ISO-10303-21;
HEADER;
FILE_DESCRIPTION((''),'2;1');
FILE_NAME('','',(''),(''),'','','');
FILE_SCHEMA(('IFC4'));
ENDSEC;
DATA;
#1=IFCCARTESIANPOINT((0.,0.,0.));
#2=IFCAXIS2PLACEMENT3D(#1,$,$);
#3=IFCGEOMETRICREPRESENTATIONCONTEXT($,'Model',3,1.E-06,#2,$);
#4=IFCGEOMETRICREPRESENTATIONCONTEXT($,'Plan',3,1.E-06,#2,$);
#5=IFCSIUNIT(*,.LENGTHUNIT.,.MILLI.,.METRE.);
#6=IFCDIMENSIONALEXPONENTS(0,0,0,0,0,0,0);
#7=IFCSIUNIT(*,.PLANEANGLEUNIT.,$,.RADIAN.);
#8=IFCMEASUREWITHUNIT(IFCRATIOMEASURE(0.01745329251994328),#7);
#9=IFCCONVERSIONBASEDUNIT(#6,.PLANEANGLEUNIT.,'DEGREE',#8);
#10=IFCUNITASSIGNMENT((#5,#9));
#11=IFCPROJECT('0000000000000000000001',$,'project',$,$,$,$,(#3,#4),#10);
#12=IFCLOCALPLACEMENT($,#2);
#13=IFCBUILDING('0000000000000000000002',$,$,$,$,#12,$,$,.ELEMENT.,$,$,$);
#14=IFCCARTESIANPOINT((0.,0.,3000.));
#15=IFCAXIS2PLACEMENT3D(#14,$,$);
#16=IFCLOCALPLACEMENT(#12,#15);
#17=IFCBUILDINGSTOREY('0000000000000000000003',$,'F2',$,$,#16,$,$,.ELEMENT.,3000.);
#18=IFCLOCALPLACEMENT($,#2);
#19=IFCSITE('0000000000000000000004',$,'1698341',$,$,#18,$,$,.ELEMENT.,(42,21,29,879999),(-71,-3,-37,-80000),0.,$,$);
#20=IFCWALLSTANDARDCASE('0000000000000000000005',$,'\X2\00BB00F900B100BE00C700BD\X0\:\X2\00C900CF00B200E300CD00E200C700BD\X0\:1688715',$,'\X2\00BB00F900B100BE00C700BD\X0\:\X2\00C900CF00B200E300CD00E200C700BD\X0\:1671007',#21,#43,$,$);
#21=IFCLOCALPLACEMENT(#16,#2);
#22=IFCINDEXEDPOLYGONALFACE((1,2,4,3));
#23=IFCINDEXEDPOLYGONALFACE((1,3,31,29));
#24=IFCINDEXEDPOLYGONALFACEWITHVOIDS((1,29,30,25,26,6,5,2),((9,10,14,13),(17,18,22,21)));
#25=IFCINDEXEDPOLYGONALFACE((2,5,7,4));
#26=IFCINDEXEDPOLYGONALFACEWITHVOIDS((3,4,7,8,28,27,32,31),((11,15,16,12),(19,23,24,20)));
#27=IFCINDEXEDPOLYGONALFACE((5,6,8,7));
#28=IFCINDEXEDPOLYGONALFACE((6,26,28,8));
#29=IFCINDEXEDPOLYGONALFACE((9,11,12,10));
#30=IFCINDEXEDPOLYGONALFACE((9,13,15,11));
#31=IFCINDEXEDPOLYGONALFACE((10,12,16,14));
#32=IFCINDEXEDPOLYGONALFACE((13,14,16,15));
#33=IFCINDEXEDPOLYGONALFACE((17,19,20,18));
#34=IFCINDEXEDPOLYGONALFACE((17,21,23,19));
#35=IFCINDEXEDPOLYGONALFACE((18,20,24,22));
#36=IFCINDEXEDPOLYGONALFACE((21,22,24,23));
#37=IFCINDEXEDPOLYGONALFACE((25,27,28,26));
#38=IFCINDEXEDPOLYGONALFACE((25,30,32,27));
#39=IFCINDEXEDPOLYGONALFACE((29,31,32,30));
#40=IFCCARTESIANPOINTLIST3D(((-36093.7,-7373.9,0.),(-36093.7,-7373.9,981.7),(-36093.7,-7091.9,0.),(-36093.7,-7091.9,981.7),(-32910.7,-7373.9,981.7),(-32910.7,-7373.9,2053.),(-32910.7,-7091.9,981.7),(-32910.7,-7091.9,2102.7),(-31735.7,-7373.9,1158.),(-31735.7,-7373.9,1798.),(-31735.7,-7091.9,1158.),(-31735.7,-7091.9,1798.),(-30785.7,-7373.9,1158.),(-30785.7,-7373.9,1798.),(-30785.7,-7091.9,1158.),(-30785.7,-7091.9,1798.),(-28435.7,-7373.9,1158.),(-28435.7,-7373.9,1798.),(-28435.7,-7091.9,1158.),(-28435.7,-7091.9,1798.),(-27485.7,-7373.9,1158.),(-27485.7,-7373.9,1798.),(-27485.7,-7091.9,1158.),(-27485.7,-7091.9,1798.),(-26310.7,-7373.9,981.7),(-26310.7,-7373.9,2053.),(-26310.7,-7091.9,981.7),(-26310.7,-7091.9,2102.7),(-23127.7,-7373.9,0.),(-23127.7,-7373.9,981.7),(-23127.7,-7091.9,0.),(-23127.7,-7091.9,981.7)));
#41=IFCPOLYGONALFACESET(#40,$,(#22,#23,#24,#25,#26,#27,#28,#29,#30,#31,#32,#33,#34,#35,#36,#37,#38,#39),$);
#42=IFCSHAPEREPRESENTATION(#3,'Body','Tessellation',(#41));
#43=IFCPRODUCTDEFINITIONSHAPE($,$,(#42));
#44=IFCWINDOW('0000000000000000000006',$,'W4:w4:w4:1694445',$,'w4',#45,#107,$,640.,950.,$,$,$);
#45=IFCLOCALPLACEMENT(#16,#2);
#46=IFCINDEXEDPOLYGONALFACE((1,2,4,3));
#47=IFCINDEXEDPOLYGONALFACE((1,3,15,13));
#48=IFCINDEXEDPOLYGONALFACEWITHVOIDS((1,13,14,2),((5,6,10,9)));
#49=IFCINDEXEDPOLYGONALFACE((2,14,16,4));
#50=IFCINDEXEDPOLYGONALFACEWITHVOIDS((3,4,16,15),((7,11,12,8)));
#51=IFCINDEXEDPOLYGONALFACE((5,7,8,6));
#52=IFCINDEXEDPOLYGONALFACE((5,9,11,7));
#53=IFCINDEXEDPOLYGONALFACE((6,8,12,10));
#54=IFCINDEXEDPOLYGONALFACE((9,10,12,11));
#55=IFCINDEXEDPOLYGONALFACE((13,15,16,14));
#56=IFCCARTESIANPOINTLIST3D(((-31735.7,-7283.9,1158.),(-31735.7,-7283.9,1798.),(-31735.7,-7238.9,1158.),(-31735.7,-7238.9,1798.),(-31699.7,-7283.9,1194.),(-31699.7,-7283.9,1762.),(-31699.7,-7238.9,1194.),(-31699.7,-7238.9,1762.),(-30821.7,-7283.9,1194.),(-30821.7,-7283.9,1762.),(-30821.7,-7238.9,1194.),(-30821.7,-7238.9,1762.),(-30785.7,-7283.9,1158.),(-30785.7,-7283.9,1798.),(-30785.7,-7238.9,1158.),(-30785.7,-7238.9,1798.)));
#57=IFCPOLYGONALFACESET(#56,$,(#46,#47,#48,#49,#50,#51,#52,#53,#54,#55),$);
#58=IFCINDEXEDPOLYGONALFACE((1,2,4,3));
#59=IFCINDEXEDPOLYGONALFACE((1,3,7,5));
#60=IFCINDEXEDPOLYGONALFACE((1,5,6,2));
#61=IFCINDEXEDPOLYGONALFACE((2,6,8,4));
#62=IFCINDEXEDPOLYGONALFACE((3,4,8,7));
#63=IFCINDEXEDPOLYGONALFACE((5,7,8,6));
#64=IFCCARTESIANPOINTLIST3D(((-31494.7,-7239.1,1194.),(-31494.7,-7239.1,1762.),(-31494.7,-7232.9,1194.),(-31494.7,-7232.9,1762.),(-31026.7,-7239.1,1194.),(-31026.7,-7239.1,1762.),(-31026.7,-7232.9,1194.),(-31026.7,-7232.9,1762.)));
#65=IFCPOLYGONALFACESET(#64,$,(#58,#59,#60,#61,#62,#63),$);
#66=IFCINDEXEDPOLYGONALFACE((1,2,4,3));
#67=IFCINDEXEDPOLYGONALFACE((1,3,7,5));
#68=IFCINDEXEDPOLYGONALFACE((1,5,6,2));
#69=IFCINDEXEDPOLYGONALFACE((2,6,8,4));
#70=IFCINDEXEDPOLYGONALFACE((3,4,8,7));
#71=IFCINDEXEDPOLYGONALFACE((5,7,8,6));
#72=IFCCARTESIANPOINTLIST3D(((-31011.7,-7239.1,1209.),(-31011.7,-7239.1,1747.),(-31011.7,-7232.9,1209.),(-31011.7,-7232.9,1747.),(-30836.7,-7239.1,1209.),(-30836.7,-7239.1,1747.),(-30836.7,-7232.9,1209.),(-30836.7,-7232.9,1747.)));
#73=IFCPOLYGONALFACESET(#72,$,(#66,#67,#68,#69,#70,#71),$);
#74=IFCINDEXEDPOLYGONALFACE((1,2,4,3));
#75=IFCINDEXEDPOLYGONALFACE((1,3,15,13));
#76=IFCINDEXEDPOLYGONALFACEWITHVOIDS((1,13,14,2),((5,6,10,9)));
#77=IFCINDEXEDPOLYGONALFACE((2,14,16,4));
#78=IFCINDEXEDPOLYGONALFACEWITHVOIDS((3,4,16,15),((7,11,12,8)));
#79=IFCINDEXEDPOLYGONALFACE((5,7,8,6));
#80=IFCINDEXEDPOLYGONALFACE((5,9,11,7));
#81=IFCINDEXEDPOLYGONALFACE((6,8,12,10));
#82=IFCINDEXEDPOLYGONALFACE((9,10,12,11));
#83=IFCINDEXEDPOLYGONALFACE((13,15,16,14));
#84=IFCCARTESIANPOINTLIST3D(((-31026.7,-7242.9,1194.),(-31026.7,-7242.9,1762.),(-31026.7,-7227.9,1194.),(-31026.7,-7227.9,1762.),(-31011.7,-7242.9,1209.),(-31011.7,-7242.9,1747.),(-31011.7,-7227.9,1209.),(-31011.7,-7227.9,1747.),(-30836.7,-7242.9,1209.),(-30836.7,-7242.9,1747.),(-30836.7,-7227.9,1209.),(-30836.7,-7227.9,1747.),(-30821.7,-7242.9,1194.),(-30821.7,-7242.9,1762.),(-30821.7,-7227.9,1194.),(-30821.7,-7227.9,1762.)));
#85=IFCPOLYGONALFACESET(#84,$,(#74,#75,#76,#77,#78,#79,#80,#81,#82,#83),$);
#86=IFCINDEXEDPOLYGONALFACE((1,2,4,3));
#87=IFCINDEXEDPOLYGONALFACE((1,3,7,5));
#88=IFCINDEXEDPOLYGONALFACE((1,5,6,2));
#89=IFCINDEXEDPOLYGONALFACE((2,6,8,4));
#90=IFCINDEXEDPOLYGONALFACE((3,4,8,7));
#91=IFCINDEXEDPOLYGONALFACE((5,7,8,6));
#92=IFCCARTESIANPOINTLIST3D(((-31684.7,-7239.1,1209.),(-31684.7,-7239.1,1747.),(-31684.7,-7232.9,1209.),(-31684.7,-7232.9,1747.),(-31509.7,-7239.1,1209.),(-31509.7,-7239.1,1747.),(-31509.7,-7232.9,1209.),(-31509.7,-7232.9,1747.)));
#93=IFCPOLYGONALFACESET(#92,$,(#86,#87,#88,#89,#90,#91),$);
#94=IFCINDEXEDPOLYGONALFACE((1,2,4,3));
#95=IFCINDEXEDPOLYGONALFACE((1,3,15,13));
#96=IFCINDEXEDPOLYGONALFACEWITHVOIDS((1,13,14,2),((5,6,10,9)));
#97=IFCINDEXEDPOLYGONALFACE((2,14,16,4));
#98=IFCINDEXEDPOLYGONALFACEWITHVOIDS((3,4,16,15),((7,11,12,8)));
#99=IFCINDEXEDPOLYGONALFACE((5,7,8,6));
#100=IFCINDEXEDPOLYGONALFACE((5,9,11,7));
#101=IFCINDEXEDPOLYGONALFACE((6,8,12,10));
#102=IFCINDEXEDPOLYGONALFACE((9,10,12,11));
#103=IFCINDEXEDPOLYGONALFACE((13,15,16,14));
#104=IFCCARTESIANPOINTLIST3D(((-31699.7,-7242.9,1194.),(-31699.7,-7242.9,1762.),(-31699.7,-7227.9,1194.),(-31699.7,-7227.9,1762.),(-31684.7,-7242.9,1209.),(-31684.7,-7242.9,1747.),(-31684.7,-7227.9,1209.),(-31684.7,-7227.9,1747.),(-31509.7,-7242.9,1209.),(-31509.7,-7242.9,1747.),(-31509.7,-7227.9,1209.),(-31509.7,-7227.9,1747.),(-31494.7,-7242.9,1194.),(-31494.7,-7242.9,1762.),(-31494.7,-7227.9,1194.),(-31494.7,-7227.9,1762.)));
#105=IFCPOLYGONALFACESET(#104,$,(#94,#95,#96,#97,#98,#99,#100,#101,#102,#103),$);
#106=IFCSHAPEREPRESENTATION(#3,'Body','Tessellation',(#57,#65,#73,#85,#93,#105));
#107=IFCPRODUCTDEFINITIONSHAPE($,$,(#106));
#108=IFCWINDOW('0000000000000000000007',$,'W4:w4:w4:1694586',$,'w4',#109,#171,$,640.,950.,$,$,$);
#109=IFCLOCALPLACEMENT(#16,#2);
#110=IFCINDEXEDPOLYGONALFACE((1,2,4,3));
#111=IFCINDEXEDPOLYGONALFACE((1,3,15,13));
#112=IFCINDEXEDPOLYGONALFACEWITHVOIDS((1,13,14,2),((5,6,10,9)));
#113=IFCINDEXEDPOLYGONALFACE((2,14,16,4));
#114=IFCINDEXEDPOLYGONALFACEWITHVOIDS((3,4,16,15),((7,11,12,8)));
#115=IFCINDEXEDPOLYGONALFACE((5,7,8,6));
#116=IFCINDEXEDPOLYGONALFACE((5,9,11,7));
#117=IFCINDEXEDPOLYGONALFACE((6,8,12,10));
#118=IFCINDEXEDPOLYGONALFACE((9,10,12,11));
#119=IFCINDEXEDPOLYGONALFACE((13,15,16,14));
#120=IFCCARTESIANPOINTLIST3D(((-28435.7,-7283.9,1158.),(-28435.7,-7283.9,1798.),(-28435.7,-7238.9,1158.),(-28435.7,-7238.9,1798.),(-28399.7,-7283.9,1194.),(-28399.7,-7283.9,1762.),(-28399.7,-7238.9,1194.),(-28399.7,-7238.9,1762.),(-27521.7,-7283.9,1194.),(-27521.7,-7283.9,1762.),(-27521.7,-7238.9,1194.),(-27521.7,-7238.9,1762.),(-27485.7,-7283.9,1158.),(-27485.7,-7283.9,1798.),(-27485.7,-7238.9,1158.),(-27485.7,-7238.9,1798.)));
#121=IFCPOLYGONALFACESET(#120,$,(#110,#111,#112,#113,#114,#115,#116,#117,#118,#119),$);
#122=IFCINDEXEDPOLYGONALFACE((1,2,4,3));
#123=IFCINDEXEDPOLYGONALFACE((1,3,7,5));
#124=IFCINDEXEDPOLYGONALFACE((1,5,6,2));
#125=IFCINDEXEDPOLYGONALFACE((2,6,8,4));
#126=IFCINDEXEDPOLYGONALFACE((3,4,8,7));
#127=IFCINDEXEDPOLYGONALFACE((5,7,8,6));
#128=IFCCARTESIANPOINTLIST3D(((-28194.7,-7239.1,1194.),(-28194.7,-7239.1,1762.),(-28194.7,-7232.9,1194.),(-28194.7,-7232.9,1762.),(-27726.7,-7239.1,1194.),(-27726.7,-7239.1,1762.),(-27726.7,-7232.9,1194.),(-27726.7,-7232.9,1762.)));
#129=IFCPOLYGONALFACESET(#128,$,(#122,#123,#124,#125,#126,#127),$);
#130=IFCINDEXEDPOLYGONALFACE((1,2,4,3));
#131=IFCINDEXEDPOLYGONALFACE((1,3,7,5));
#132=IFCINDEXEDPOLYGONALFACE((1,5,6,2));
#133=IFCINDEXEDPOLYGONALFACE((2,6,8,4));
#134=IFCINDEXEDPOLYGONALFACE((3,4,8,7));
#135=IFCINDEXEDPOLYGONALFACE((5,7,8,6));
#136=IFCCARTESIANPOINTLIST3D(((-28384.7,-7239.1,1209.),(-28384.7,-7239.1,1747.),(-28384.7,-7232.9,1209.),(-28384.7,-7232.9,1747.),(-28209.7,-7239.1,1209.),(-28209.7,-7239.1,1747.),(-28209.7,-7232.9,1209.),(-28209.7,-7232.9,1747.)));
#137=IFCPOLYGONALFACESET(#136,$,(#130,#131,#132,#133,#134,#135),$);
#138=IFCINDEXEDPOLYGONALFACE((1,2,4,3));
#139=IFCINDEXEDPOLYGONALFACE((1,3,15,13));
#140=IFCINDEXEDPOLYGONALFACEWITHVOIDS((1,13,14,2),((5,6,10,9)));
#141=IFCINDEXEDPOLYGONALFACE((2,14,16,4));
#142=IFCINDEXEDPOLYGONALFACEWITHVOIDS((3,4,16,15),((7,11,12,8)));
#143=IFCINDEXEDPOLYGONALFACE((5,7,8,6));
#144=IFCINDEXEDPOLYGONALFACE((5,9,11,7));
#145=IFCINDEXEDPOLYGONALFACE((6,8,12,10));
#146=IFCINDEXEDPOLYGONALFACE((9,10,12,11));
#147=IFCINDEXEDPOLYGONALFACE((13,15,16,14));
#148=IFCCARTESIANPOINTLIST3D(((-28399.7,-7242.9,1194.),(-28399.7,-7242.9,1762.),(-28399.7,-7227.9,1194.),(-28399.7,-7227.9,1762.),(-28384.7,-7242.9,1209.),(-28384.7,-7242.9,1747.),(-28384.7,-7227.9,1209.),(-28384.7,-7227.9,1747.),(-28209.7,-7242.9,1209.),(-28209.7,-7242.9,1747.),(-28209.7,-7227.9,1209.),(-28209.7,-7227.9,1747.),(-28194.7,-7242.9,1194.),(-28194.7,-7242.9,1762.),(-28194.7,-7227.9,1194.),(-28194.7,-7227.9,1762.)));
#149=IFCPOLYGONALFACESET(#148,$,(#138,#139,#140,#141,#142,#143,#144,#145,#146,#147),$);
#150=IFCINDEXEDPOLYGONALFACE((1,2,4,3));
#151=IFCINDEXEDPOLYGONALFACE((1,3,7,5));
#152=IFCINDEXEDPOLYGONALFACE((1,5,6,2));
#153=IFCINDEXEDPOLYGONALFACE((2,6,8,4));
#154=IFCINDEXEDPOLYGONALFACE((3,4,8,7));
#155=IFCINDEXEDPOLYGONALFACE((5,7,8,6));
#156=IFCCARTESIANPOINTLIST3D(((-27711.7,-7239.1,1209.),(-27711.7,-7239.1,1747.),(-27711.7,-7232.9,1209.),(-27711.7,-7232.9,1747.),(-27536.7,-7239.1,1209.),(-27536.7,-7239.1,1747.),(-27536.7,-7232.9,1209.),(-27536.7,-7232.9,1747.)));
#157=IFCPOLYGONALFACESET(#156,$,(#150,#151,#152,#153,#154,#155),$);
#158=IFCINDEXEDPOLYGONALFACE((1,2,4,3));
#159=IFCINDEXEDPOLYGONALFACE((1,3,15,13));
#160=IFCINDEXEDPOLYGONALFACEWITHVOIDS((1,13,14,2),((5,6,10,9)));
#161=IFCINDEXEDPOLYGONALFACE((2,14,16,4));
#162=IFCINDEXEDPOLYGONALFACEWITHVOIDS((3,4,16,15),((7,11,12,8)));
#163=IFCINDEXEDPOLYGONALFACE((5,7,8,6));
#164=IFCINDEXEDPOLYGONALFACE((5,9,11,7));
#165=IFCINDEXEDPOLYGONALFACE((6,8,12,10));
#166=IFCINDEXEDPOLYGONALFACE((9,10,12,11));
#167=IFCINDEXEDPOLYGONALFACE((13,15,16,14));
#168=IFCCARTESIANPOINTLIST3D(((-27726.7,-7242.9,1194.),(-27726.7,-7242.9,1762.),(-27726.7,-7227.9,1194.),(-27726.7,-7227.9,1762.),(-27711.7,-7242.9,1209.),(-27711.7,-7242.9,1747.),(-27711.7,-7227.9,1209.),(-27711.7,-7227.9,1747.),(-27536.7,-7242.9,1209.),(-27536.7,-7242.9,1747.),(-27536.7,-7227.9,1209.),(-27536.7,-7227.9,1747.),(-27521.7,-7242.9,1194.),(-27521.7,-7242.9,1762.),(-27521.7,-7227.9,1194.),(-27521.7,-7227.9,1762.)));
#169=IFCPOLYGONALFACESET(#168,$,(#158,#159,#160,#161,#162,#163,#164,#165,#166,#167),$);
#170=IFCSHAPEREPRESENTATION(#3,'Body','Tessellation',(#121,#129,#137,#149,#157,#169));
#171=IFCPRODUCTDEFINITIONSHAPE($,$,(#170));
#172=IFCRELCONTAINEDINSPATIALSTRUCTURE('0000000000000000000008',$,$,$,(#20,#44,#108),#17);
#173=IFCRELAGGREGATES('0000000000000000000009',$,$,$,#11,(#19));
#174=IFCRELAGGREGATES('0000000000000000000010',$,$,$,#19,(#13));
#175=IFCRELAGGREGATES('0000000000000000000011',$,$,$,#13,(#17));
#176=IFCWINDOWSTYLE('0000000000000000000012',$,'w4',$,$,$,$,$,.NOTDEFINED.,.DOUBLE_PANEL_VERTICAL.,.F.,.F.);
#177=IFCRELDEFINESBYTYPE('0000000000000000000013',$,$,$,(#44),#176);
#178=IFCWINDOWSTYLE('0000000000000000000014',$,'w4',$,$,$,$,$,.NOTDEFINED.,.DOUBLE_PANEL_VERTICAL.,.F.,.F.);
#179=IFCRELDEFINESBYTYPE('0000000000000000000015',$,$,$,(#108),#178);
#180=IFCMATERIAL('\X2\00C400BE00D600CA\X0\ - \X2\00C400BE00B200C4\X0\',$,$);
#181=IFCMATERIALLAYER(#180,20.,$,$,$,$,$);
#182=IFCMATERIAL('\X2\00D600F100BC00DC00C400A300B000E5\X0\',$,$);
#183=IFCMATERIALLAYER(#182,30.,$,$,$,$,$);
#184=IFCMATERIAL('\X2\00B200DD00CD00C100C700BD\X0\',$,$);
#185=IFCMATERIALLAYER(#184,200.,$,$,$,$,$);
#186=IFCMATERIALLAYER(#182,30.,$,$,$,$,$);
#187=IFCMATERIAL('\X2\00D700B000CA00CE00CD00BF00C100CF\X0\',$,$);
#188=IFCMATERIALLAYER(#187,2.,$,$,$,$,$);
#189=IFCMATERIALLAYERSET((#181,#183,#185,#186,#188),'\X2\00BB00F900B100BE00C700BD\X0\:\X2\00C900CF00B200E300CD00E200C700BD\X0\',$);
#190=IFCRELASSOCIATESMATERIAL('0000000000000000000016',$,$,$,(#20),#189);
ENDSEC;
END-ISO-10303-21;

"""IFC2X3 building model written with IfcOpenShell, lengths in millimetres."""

from ifc_helpers import new_model, entity, si_unit, converted_unit, frame, frame_2d, origin, origin_2d_with_axis, place, context, project, spatial, polyline, rectangle, outline, extrude, clip, halfspace, bounded_halfspace, source, transform, mapped, material, layer, layer_set, layer_usage, type_object, type_shapes, element, fill, save


model = new_model("IFC2X3")

# Units and contexts
model_context = context("Model", 3, precision=1e-06, world=origin())
plan_context = context("Plan", 3, precision=1e-06, world=origin())
ifc_project = project(units=[si_unit("LENGTHUNIT", "METRE", prefix="MILLI"), converted_unit("PLANEANGLEUNIT", "DEGREE", entity("IfcRatioMeasure", 0.01745329251994328), si_unit("PLANEANGLEUNIT", "RADIAN"), dimensions=[0, 0, 0, 0, 0, 0, 0])], contexts=[model_context, plan_context])

# Site, building, storey
site_placement = place(None, origin())
site = spatial("IfcSite", under=ifc_project, at=site_placement, Name="1698341", CompositionType="ELEMENT", RefLatitude=(42, 21, 29, 879999), RefLongitude=(-71, -3, -37, -80000), RefElevation=0.0)
building_placement = place(None, origin())
building = spatial("IfcBuilding", under=site, at=building_placement, CompositionType="ELEMENT")
storey_placement = place(building_placement, frame((0.0, 0.0, 3000.0)))
storey = spatial("IfcBuildingStorey", under=building, at=storey_placement, Name="F2", CompositionType="ELEMENT", Elevation=3000.0)

# Shared definitions
ifc_material_1 = material(Name="Öñ¼ÜÄ£°å")

# Shared definitions
ifc_material_2 = material(Name="Ä¾ÖÊ - Ä¾²Ä")
ifc_layer_1 = layer(ifc_material_2, 20.0)
ifc_layer_2 = layer(ifc_material_1, 30.0)
ifc_material_3 = material(Name="²ÝÍÁÇ½")
ifc_layer_3 = layer(ifc_material_3, 200.0)
ifc_layer_4 = layer(ifc_material_1, 30.0)
ifc_material_4 = material(Name="×°ÊÎÍ¿ÁÏ")
ifc_layer_5 = layer(ifc_material_4, 2.0)
ifc_layer_set_1 = layer_set([ifc_layer_1, ifc_layer_2, ifc_layer_3, ifc_layer_4, ifc_layer_5], Name="»ù±¾Ç½:ÉÏ²ãÍâÇ½")

# Shared definitions
window_style_1 = type_object("IfcWindowStyle", Name="w4", ConstructionType="NOTDEFINED", OperationType="DOUBLE_PANEL_VERTICAL", ParameterTakesPrecedence=False, Sizeable=False)
shared_shape_1 = source(origin(), model_context, "Body", "SweptSolid", [
    extrude(outline(polyline([(-320.0, -475.0), (320.0, -475.0), (320.0, 475.0), (-320.0, 475.0), (-320.0, -475.0)]), holes=[polyline([(284.0, -439.0), (-284.0, -439.0), (-284.0, 439.0), (284.0, 439.0), (284.0, -439.0)])]), frame((475.0, -135.0, 320.0), z_axis=(0.0, 1.0, 0.0), x_axis=(0.0, 0.0, 1.0)), (0.0, 0.0, 1.0), 45.0),
    extrude(rectangle(XDim=6.3, YDim=468.0, at=origin_2d_with_axis()), frame((475.0, -137.9, 36.0), z_axis=(0.0, 0.0, 1.0), x_axis=(0.0, 1.0, 0.0)), (0.0, 0.0, 1.0), 568.0),
    extrude(rectangle(XDim=6.3, YDim=175.0, at=origin_2d_with_axis()), frame((138.5, -137.9, 51.0), z_axis=(0.0, 0.0, 1.0), x_axis=(0.0, 1.0, 0.0)), (0.0, 0.0, 1.0), 538.0),
    extrude(outline(polyline([(-102.5, -284.0), (102.5, -284.0), (102.5, 284.0), (-102.5, 284.0), (-102.5, -284.0)]), holes=[polyline([(87.5, -269.0), (-87.5, -269.0), (-87.5, 269.0), (87.5, 269.0), (87.5, -269.0)])]), frame((138.5, -146.0, 320.0), z_axis=(0.0, 1.0, 0.0), x_axis=(-1.0, 0.0, 0.0)), (0.0, 0.0, 1.0), 15.0),
    extrude(rectangle(XDim=6.3, YDim=175.0, at=origin_2d_with_axis()), frame((811.5, -137.9, 51.0), z_axis=(0.0, 0.0, 1.0), x_axis=(0.0, 1.0, 0.0)), (0.0, 0.0, 1.0), 538.0),
    extrude(outline(polyline([(-102.5, -284.0), (102.5, -284.0), (102.5, 284.0), (-102.5, 284.0), (-102.5, -284.0)]), holes=[polyline([(87.5, -269.0), (-87.5, -269.0), (-87.5, 269.0), (87.5, 269.0), (87.5, -269.0)])]), frame((811.5, -146.0, 320.0), z_axis=(0.0, 1.0, 0.0), x_axis=(-1.0, 0.0, 0.0)), (0.0, 0.0, 1.0), 15.0),
])
type_shapes(window_style_1, [shared_shape_1])
window_style_2 = type_object("IfcWindowStyle", Name="w4", ConstructionType="NOTDEFINED", OperationType="DOUBLE_PANEL_VERTICAL", ParameterTakesPrecedence=False, Sizeable=False)
shared_shape_2 = source(origin(), model_context, "Body", "SweptSolid", [
    extrude(outline(polyline([(-475.0, -320.0), (475.0, -320.0), (475.0, 320.0), (-475.0, 320.0), (-475.0, -320.0)]), holes=[polyline([(-439.0, 284.0), (439.0, 284.0), (439.0, -284.0), (-439.0, -284.0), (-439.0, 284.0)])]), frame((-177.3, 192.0, 320.0), z_axis=(0.0, -1.0, 0.0), x_axis=(-1.0, 0.0, 0.0)), (0.0, 0.0, 1.0), 45.0),
    extrude(rectangle(XDim=468.0, YDim=6.3, at=origin_2d_with_axis()), frame((-177.3, 144.1, 36.0)), (0.0, 0.0, 1.0), 568.0),
    extrude(rectangle(XDim=175.0, YDim=6.3, at=origin_2d_with_axis()), frame((159.2, 144.1, 51.0)), (0.0, 0.0, 1.0), 538.0),
    extrude(outline(polyline([(-284.0, -102.5), (284.0, -102.5), (284.0, 102.5), (-284.0, 102.5), (-284.0, -102.5)]), holes=[polyline([(-269.0, 87.5), (269.0, 87.5), (269.0, -87.5), (-269.0, -87.5), (-269.0, 87.5)])]), frame((159.2, 151.0, 320.0), z_axis=(0.0, -1.0, 0.0), x_axis=(0.0, 0.0, 1.0)), (0.0, 0.0, 1.0), 15.0),
    extrude(rectangle(XDim=175.0, YDim=6.3, at=origin_2d_with_axis()), frame((-513.8, 144.1, 51.0)), (0.0, 0.0, 1.0), 538.0),
    extrude(outline(polyline([(-284.0, -102.5), (284.0, -102.5), (284.0, 102.5), (-284.0, 102.5), (-284.0, -102.5)]), holes=[polyline([(-269.0, 87.5), (269.0, 87.5), (269.0, -87.5), (-269.0, -87.5), (-269.0, 87.5)])]), frame((-513.8, 151.0, 320.0), z_axis=(0.0, -1.0, 0.0), x_axis=(0.0, 0.0, 1.0)), (0.0, 0.0, 1.0), 15.0),
])
type_shapes(window_style_2, [shared_shape_2])

# Wall, openings, windows
ifc_layer_usage_1 = layer_usage(ifc_layer_set_1, "AXIS2", "NEGATIVE", 141.0)
wall_1_placement = place(storey_placement, frame((-23127.7, -7232.9, 0.0), z_axis=(0.0, 0.0, 1.0), x_axis=(-1.0, 0.0, 0.0)))
wall_1 = element("IfcWallStandardCase", 1, at=wall_1_placement, inside=storey, material=ifc_layer_usage_1, Name="»ù±¾Ç½:ÉÏ²ãÍâÇ½:1688715", ObjectType="»ù±¾Ç½:ÉÏ²ãÍâÇ½:1671007", context=model_context, shape_type="Clipping", body=[
    clip(clip(clip(extrude(rectangle(XDim=12966.0, YDim=282.0, at=frame_2d((6483.0, 0.0), x_axis=(-1.0, 0.0))), origin(), (0.0, 0.0, 1.0), 3200.0), bounded_halfspace(frame((3098.0, -141.0, 2102.7), z_axis=(0.0, -0.173648, -0.984808), x_axis=(1.0, 0.0, 0.0)), True, frame((3098.0, -141.0, 2102.7)), polyline([(0.0, 0.0), (170.0, 0.0), (3280.0, 0.0), (3490.0, 0.0), (6600.0, 0.0), (6770.0, 0.0), (6770.0, 282.0), (0.0, 282.0), (0.0, 0.0)]))), halfspace(frame((13107.0, 0.0, 981.7), z_axis=(0.5551, 0.0, 0.831784), x_axis=(0.0, 1.0, 0.0)), False)), halfspace(frame((3183.0, 0.0, 3200.0), z_axis=(-0.5551, 0.0, 0.831784), x_axis=(0.0, 1.0, 0.0)), False)),
])
opening_1_placement = place(wall_1_placement, origin())
opening_1 = element("IfcOpeningElement", 2, at=opening_1_placement, cuts=wall_1, ObjectType="Opening", context=model_context, shape_type="SweptSolid", body=[
    extrude(rectangle(XDim=640.0, YDim=950.0, at=frame_2d((0.0, 0.0), x_axis=(0.0, 1.0))), frame((8133.0, -141.0, 1478.0), z_axis=(0.0, 1.0, 0.0), x_axis=(-1.0, 0.0, 0.0)), (0.0, 0.0, 1.0), 282.0),
])
opening_2_placement = place(wall_1_placement, origin())
opening_2 = element("IfcOpeningElement", 3, at=opening_2_placement, cuts=wall_1, ObjectType="Opening", context=model_context, shape_type="SweptSolid", body=[
    extrude(rectangle(XDim=640.0, YDim=950.0, at=origin_2d_with_axis()), frame((4833.0, -141.0, 1478.0), z_axis=(0.0, 1.0, 0.0), x_axis=(0.0, 0.0, 1.0)), (0.0, 0.0, 1.0), 282.0),
])
opening_3_placement = place(wall_1_placement, frame((10891.0, 141.0, 1721.1)))
element("IfcOpeningElement", 4, at=opening_3_placement, cuts=wall_1, ObjectType="Opening", context=model_context, shape_type="SweptSolid", body=[
    extrude(outline(polyline([(-2253.7, -615.1), (1742.5, -615.1), (511.2, 1230.1), (-2253.7, -615.1)])), frame((0.0, 0.0, 0.0), z_axis=(0.0, -1.0, 0.0), x_axis=(-0.831784, 0.0, 0.5551)), (0.0, 0.0, 1.0), 282.0),
])
opening_4_placement = place(wall_1_placement, frame((2075.0, 141.0, 1721.1)))
element("IfcOpeningElement", 5, at=opening_4_placement, cuts=wall_1, ObjectType="Opening", context=model_context, shape_type="SweptSolid", body=[
    extrude(outline(polyline([(-1742.5, -615.1), (2253.7, -615.1), (-511.2, 1230.1), (-1742.5, -615.1)])), frame((0.0, 0.0, 0.0), z_axis=(0.0, -1.0, 0.0), x_axis=(-0.831784, 0.0, -0.5551)), (0.0, 0.0, 1.0), 282.0),
])
window_1_placement = place(opening_1_placement, frame((7658.0, 141.0, 1158.0)))
window_1 = element("IfcWindow", 6, at=window_1_placement, inside=storey, type_object=window_style_1, Name="W4:w4:w4:1694445", ObjectType="w4", OverallHeight=640.0, OverallWidth=950.0, context=model_context, shape_type="MappedRepresentation", body=[
    mapped(shared_shape_1, transform((0.0, 0.0, 0.0), scale=1.0)),
])
fill(opening_1, window_1)
window_2_placement = place(opening_2_placement, frame((5010.3, -141.0, 1158.0)))
window_2 = element("IfcWindow", 7, at=window_2_placement, inside=storey, type_object=window_style_2, Name="W4:w4:w4:1694586", ObjectType="w4", OverallHeight=640.0, OverallWidth=950.0, context=model_context, shape_type="MappedRepresentation", body=[
    mapped(shared_shape_2, transform((0.0, 0.0, 0.0), scale=1.0)),
])
fill(opening_2, window_2)

save(model, "model.ifc")
